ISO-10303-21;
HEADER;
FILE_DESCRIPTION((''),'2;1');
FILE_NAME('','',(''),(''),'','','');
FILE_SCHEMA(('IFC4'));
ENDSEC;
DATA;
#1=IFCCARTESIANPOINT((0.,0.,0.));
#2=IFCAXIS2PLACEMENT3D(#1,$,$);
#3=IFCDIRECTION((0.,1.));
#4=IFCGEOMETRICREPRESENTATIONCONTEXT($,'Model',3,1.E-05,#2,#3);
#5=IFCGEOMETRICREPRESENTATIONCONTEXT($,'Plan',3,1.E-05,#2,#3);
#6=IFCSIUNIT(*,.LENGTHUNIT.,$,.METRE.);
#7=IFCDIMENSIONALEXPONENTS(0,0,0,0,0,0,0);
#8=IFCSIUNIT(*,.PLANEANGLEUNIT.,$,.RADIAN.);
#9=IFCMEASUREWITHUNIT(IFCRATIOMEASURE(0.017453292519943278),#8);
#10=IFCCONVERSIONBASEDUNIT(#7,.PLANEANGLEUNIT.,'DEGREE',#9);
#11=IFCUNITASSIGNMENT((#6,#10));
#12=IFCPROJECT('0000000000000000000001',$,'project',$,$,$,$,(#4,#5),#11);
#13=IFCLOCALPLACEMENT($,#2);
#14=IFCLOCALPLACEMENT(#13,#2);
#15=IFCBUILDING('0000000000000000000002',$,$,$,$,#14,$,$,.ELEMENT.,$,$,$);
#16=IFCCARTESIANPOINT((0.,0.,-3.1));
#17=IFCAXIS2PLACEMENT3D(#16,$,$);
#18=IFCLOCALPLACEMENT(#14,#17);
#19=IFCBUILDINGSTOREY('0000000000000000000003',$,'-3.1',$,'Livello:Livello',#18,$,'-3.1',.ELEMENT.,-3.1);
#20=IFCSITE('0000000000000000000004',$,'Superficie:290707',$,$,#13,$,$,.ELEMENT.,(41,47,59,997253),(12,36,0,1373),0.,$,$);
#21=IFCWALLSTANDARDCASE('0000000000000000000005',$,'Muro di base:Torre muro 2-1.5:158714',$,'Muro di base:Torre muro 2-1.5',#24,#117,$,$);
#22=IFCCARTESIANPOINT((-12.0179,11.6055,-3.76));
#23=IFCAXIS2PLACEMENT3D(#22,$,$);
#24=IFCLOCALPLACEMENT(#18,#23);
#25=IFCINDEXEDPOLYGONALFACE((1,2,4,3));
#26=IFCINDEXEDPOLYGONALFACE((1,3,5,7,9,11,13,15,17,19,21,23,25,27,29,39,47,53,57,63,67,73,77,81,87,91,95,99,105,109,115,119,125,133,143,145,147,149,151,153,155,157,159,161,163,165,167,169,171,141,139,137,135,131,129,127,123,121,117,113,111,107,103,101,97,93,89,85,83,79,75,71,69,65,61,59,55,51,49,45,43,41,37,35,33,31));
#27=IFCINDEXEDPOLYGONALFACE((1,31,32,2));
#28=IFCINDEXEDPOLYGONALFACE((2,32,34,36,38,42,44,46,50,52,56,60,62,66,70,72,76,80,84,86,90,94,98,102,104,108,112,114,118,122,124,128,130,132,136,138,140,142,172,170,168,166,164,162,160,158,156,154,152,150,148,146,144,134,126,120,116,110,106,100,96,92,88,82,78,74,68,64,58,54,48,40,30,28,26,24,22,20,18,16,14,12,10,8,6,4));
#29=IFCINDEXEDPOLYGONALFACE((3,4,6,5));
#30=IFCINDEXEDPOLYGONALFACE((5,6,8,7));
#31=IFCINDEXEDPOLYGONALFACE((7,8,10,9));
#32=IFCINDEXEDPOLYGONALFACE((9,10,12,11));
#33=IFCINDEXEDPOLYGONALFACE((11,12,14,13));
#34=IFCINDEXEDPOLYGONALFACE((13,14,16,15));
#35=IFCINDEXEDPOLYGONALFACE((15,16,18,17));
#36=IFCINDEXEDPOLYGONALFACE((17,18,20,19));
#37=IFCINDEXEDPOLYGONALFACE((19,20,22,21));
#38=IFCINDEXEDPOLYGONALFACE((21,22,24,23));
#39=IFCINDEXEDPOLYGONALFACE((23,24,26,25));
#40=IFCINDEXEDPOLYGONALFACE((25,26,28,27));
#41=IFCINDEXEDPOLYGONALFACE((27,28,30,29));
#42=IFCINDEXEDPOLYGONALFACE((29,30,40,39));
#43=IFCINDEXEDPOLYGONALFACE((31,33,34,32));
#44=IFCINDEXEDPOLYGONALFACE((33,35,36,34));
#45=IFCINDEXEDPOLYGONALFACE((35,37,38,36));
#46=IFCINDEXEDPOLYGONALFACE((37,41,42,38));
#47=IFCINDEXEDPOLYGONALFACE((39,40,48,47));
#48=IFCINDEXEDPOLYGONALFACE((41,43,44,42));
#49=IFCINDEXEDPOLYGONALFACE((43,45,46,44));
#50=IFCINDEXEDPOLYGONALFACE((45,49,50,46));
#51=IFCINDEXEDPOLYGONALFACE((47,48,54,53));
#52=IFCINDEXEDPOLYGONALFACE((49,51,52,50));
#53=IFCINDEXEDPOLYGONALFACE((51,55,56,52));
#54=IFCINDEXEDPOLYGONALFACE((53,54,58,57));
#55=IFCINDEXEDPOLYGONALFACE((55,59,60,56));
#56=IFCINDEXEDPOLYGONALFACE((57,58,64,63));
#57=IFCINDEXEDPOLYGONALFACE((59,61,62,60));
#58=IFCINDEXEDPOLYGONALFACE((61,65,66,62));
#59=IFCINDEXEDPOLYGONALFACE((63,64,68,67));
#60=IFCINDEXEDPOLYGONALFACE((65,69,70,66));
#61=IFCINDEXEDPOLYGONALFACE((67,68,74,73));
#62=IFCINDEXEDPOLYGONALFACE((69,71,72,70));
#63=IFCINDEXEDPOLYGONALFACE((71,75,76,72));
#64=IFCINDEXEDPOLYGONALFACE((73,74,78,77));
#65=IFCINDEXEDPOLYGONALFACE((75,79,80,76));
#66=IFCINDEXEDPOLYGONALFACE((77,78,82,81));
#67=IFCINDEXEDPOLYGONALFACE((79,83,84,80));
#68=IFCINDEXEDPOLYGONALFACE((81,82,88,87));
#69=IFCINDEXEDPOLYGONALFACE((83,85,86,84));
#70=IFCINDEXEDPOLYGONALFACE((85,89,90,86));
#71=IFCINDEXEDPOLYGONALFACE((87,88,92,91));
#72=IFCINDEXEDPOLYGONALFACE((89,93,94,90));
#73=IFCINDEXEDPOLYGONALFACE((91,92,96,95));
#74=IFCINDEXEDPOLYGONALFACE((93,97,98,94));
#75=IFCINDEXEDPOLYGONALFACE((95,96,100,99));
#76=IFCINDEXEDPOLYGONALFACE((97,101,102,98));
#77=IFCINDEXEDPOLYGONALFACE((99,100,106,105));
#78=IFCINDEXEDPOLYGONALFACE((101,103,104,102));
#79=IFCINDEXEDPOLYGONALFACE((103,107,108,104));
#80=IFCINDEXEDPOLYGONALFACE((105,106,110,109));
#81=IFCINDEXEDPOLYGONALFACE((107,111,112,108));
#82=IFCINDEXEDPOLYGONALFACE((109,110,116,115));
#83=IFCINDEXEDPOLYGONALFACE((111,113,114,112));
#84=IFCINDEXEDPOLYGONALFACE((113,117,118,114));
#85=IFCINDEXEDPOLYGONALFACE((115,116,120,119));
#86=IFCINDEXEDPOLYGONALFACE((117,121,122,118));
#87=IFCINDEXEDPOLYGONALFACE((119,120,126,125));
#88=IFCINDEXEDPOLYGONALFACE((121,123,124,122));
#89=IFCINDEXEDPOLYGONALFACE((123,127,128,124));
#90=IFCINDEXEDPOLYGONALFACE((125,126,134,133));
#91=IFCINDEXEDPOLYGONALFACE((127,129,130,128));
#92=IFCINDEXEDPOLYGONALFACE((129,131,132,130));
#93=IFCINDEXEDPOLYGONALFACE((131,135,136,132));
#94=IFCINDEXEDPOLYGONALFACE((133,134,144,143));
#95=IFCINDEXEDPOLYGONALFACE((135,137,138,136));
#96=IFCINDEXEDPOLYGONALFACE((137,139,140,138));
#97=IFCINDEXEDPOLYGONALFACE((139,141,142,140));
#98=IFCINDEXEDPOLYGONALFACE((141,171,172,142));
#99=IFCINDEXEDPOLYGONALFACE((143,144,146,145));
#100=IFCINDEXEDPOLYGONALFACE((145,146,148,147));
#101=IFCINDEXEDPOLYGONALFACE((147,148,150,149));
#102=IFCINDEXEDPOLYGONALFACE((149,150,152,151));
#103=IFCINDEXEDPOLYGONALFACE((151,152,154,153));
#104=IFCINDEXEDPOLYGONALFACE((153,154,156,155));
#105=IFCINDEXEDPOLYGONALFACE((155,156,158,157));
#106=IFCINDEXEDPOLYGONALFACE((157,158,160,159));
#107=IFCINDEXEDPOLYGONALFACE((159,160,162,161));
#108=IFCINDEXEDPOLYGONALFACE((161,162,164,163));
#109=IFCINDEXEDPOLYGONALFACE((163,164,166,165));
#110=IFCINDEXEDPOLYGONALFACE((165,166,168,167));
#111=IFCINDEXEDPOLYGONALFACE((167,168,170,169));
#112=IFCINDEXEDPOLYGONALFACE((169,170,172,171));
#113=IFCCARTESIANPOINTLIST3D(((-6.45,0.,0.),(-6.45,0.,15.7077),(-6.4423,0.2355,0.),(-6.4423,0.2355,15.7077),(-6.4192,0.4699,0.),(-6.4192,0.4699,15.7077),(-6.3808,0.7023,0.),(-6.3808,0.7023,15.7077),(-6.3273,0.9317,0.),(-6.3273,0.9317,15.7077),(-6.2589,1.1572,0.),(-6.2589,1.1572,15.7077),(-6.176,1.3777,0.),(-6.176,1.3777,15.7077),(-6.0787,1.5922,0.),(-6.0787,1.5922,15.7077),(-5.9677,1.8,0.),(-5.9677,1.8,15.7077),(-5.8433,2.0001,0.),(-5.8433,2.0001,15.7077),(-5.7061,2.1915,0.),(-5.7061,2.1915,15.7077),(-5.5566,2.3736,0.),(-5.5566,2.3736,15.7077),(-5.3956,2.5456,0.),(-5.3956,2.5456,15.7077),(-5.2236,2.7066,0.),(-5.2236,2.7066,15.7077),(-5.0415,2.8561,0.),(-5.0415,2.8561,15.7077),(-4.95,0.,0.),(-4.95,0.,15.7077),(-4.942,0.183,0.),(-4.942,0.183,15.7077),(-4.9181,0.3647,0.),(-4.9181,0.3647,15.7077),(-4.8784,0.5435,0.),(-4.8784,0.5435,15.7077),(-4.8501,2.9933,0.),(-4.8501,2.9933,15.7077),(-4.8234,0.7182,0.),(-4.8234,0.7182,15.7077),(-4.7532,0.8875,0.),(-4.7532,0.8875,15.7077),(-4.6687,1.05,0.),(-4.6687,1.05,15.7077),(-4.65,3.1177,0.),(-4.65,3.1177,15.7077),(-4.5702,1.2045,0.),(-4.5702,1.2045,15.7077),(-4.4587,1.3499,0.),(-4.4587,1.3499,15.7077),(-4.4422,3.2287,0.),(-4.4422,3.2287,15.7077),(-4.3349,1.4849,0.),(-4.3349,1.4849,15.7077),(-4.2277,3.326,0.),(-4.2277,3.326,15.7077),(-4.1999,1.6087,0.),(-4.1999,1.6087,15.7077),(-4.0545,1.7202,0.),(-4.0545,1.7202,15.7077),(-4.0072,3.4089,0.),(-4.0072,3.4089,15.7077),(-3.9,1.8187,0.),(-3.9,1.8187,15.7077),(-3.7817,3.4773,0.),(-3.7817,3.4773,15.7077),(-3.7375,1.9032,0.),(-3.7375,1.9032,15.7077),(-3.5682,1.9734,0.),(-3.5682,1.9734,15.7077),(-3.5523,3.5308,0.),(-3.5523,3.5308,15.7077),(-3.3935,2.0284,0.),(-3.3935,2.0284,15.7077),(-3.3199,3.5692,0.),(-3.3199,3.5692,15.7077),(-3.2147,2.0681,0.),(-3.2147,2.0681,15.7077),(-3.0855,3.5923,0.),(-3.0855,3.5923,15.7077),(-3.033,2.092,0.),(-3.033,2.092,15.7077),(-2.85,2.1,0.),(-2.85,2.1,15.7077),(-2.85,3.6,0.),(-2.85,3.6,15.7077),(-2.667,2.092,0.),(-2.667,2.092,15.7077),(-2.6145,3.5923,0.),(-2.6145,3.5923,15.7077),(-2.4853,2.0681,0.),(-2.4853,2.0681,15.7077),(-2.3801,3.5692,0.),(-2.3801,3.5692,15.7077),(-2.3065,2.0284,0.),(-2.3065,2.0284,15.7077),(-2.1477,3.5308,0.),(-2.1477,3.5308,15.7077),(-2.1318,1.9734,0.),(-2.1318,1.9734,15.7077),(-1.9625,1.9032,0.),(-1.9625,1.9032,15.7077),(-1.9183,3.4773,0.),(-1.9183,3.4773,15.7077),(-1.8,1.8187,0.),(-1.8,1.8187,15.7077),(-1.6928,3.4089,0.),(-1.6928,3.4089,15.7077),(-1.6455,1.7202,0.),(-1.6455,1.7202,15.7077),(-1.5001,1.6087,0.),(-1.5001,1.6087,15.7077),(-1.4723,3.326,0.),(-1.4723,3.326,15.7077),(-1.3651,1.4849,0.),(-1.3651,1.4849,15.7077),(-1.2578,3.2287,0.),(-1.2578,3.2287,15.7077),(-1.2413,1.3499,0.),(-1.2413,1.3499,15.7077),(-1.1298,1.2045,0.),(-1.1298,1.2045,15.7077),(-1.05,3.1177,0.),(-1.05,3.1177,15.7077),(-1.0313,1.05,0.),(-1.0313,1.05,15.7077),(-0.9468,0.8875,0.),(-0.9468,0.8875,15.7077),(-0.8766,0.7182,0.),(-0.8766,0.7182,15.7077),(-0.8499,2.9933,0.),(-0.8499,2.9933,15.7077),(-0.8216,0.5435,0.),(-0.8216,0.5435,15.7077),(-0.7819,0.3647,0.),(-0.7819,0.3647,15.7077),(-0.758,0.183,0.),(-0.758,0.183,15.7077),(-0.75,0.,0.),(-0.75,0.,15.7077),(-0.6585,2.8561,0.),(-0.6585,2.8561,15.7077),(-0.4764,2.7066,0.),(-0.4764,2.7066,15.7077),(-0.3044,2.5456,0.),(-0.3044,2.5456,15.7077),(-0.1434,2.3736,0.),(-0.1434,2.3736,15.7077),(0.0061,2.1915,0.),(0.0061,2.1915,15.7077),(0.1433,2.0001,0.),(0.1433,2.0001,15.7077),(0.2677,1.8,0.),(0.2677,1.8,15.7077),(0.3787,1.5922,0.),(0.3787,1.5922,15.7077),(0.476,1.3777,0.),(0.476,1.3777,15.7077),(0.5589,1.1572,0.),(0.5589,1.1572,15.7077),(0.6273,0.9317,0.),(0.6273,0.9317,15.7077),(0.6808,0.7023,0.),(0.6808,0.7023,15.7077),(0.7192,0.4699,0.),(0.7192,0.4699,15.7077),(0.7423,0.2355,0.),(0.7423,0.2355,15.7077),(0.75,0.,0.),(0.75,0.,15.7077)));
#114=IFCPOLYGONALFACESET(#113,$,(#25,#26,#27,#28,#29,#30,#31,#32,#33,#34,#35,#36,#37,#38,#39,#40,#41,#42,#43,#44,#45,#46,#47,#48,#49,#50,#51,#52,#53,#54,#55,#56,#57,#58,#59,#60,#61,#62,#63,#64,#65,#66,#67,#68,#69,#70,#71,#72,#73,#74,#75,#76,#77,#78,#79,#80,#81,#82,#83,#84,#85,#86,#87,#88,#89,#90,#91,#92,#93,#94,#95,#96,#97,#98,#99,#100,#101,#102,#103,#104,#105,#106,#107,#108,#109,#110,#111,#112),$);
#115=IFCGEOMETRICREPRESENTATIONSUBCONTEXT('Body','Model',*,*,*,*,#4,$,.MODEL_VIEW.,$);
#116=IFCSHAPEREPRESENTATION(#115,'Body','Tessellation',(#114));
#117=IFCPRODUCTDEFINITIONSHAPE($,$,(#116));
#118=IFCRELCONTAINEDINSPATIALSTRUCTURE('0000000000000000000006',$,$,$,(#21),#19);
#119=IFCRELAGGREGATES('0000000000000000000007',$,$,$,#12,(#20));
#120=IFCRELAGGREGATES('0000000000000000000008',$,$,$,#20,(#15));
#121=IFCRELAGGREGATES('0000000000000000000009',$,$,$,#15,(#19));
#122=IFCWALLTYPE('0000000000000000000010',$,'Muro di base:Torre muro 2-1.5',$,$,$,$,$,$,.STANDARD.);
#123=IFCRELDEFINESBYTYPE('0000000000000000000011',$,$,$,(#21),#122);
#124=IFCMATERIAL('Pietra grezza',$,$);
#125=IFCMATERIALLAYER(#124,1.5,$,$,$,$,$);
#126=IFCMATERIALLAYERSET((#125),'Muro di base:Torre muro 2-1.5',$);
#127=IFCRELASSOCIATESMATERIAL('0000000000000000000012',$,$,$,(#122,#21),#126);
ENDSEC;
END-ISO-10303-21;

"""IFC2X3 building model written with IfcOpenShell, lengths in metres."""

from ifc_helpers import new_model, entity, si_unit, converted_unit, direction, frame, frame_2d, origin, place, context, subcontext, project, spatial, polyline, circle_curve, parameter, trimmed, segment, composite_curve, outline, extrude, material, layer, layer_set, layer_usage, type_object, element, save


model = new_model("IFC2X3")

# Units and contexts
model_context = context("Model", 3, precision=1e-05, world=origin(), true_north=direction((0.0, 1.0)))
plan_context = context("Plan", 3, precision=1e-05, world=origin(), true_north=direction((0.0, 1.0)))
body_context = subcontext(model_context, "Body", "Model", "MODEL_VIEW")
ifc_project = project(units=[si_unit("LENGTHUNIT", "METRE"), converted_unit("PLANEANGLEUNIT", "DEGREE", entity("IfcRatioMeasure", 0.017453292519943278), si_unit("PLANEANGLEUNIT", "RADIAN"), dimensions=[0, 0, 0, 0, 0, 0, 0])], contexts=[model_context, plan_context])

# Site, building, storey
site_placement = place(None, origin())
site = spatial("IfcSite", under=ifc_project, at=site_placement, Name="Superficie:290707", CompositionType="ELEMENT", RefLatitude=(41, 47, 59, 997253), RefLongitude=(12, 36, 0, 1373), RefElevation=0.0)
building_placement = place(site_placement, origin())
building = spatial("IfcBuilding", under=site, at=building_placement, CompositionType="ELEMENT")
storey_placement = place(building_placement, frame((0.0, 0.0, -3.1)))
storey = spatial("IfcBuildingStorey", under=building, at=storey_placement, Name="-3.1", ObjectType="Livello:Livello", LongName="-3.1", CompositionType="ELEMENT", Elevation=-3.1)

# Wall
ifc_material_1 = material(Name="Pietra grezza")
ifc_layer_1 = layer(ifc_material_1, 1.5)
ifc_layer_set_1 = layer_set([ifc_layer_1], Name="Muro di base:Torre muro 2-1.5")
ifc_layer_usage_1 = layer_usage(ifc_layer_set_1, "AXIS2", "NEGATIVE", 0.75)
wall_type_1 = type_object("IfcWallType", Name="Muro di base:Torre muro 2-1.5", PredefinedType="STANDARD", material=ifc_layer_set_1)
wall_1_placement = place(storey_placement, frame((-12.0179, 11.6055, -3.76)))
element("IfcWallStandardCase", 1, at=wall_1_placement, inside=storey, type_object=wall_type_1, material=ifc_layer_usage_1, Name="Muro di base:Torre muro 2-1.5:158714", ObjectType="Muro di base:Torre muro 2-1.5", context=body_context, shape_type="SweptSolid", body=[
    extrude(outline(composite_curve([segment(trimmed(circle_curve(frame_2d((-2.85, 0.0), x_axis=(1.0, 0.0)), 2.1), [parameter(0.0)], [parameter(180.0)], True, "PARAMETER"), False, "CONTINUOUS"), segment(polyline([(-0.75, 0.0), (0.75, 0.0)]), True, "CONTINUOUS"), segment(trimmed(circle_curve(frame_2d((-2.85, 0.0), x_axis=(1.0, 0.0)), 3.6), [parameter(0.0)], [parameter(180.0)], True, "PARAMETER"), True, "CONTINUOUS"), segment(polyline([(-6.45, 0.0), (-4.95, 0.0)]), True, "CONTINUOUS")], self_intersect=False)), origin(), (0.0, 0.0, 1.0), 15.7077),
])

save(model, "model.ifc")
